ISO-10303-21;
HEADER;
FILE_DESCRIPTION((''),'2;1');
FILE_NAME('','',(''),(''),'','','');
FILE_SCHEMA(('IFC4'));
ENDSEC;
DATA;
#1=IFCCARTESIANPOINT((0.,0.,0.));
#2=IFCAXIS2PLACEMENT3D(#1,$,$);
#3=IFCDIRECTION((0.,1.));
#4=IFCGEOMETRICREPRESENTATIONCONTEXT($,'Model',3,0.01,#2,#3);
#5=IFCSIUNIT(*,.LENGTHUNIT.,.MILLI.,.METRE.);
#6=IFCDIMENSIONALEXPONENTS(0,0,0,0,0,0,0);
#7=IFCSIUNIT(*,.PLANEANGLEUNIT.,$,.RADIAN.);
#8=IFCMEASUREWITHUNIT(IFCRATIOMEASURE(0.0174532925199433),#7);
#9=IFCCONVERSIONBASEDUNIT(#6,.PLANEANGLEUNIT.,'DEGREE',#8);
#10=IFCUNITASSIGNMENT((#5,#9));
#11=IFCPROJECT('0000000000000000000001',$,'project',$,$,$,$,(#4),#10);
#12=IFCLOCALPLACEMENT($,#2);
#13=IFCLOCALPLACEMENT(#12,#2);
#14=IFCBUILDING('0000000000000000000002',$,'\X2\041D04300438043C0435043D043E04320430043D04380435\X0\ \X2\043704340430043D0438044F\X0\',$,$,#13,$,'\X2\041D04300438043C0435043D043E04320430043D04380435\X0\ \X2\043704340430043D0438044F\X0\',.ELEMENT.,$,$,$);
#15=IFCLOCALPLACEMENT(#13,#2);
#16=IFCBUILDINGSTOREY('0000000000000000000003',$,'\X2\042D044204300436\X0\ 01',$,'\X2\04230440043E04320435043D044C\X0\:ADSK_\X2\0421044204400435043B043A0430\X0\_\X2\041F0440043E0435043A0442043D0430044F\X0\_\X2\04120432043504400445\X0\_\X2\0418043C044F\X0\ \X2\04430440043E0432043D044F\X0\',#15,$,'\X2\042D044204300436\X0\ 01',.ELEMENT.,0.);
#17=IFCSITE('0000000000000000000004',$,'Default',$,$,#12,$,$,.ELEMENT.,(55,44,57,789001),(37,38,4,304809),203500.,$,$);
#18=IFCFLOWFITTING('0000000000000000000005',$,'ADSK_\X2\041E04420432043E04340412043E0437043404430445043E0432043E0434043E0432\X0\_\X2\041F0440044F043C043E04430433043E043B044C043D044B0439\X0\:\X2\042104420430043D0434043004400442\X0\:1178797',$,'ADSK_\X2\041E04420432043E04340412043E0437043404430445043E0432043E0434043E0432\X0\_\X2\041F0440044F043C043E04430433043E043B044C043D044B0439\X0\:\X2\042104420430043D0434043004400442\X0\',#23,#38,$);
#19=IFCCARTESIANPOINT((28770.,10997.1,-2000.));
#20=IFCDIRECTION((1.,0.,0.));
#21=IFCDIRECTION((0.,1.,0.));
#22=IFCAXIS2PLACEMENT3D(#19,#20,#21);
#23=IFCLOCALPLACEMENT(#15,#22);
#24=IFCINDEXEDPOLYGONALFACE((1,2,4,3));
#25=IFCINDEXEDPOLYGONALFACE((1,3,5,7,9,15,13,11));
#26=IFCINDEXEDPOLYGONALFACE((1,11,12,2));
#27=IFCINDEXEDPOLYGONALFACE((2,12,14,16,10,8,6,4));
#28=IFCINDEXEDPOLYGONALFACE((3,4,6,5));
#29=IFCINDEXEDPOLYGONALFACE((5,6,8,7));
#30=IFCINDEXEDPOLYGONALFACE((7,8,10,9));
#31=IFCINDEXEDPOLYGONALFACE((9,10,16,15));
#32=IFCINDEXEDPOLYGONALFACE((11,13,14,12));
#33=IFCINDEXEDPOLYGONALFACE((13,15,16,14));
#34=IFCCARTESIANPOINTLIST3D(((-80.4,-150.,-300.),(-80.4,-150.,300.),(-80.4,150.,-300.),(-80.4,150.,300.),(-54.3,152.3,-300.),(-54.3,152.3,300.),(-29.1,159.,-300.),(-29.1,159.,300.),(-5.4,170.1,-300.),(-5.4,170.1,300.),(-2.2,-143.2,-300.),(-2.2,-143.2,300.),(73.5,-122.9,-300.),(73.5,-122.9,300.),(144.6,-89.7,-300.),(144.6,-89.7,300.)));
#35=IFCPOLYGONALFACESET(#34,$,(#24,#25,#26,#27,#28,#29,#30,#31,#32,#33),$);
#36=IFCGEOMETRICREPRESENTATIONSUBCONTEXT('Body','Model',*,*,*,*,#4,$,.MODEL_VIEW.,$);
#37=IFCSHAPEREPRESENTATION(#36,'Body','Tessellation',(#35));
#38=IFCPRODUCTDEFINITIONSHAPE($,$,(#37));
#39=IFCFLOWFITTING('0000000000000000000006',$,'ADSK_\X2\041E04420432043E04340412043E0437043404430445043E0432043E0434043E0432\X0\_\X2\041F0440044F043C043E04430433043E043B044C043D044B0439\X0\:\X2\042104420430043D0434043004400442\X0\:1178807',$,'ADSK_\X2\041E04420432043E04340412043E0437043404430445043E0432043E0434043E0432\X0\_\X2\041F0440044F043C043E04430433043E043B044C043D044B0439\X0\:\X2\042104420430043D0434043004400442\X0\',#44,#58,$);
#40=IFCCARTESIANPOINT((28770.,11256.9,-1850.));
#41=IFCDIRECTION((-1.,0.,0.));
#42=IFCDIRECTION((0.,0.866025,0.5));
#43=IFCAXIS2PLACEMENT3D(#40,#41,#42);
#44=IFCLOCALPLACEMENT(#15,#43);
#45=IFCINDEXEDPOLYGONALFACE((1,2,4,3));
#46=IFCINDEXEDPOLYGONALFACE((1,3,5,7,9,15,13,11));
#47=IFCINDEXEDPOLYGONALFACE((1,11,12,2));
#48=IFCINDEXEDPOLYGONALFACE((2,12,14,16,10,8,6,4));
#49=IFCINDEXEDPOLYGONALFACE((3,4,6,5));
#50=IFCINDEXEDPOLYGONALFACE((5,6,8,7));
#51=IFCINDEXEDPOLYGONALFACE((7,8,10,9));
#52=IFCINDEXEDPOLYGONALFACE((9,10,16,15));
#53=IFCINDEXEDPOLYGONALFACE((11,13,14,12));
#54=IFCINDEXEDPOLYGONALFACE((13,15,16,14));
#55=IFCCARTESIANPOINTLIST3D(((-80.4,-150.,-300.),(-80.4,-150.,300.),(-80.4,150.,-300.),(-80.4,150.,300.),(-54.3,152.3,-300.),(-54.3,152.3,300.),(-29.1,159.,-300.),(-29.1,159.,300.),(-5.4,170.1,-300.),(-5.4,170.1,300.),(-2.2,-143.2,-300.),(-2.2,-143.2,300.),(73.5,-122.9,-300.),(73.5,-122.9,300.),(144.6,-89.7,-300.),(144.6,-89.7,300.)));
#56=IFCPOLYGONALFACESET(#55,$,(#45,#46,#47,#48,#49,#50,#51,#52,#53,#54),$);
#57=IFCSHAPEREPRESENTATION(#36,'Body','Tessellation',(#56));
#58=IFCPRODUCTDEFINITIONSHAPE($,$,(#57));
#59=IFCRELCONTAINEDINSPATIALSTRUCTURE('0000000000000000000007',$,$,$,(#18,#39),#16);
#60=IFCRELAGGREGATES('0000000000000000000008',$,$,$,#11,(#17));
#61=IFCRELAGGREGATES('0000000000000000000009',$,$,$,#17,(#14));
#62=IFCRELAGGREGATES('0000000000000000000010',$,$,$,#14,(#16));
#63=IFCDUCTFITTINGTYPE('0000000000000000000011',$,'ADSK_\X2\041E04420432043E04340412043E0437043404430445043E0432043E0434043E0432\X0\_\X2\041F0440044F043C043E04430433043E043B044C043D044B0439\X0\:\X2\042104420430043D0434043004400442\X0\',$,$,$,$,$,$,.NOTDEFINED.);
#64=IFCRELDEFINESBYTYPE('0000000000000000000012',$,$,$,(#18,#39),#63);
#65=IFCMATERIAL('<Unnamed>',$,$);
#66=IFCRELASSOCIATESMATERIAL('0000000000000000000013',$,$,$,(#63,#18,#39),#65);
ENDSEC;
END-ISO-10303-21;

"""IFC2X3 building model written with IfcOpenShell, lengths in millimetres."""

from ifc_helpers import new_model, entity, si_unit, converted_unit, direction, frame, frame_2d, origin, place, context, subcontext, project, spatial, polyline, circle_curve, parameter, trimmed, segment, composite_curve, outline, extrude, source, transform, mapped, material, type_object, type_shapes, element, save


model = new_model("IFC2X3")

# Units and contexts
model_context = context("Model", 3, precision=0.01, world=origin(), true_north=direction((0.0, 1.0)))
body_context = subcontext(model_context, "Body", "Model", "MODEL_VIEW")
ifc_project = project(units=[si_unit("LENGTHUNIT", "METRE", prefix="MILLI"), converted_unit("PLANEANGLEUNIT", "DEGREE", entity("IfcRatioMeasure", 0.0174532925199433), si_unit("PLANEANGLEUNIT", "RADIAN"), dimensions=[0, 0, 0, 0, 0, 0, 0])], contexts=[model_context])

# Site, building, storey
site_placement = place(None, origin())
site = spatial("IfcSite", under=ifc_project, at=site_placement, Name="Default", CompositionType="ELEMENT", RefLatitude=(55, 44, 57, 789001), RefLongitude=(37, 38, 4, 304809), RefElevation=203500.0)
building_placement = place(site_placement, origin())
building = spatial("IfcBuilding", under=site, at=building_placement, Name="Наименование здания", LongName="Наименование здания", CompositionType="ELEMENT")
storey_placement = place(building_placement, origin())
storey = spatial("IfcBuildingStorey", under=building, at=storey_placement, Name="Этаж 01", ObjectType="Уровень:ADSK_Стрелка_Проектная_Вверх_Имя уровня", LongName="Этаж 01", CompositionType="ELEMENT", Elevation=0.0)

# Shared definitions
ifc_material_1 = material(Name="<Unnamed>")

# Flow fittings
duct_fitting_type_1 = type_object("IfcDuctFittingType", Name="ADSK_ОтводВоздуховодов_Прямоугольный:Стандарт", PredefinedType="NOTDEFINED", material=ifc_material_1)
shared_shape_1 = source(origin(), body_context, "Body", "SweptSolid", [
    extrude(outline(composite_curve([segment(polyline([(-170.1, -75.0), (129.9, -75.0)]), True, "CONTINUOUS"), segment(trimmed(circle_curve(frame_2d((279.9, -75.0), x_axis=(-0.866025, 0.5)), 150.0), [parameter(0.0)], [parameter(29.999999)], True, "PARAMETER"), False, "CONTINUOUS"), segment(polyline([(150.0, 0.0), (-109.8, 150.0)]), True, "CONTINUOUS"), segment(trimmed(circle_curve(frame_2d((279.9, -75.0), x_axis=(-0.866025, 0.5)), 450.0), [parameter(0.0)], [parameter(29.999999)], True, "PARAMETER"), True, "CONTINUOUS")], self_intersect=False)), frame((-5.4, 20.1, -300.0), z_axis=(0.0, 0.0, 1.0), x_axis=(-0.5, 0.866025, 0.0)), (0.0, 0.0, 1.0), 600.0),
])
type_shapes(duct_fitting_type_1, [shared_shape_1])
for number, where, z_axis, x_axis, name in (
    (1, (28770.0, 10997.1, -2000.0), (1.0, 0.0, 0.0), (0.0, 1.0, 0.0), "ADSK_ОтводВоздуховодов_Прямоугольный:Стандарт:1178797"),
    (2, (28770.0, 11256.9, -1850.0), (-1.0, 0.0, 0.0), (0.0, 0.866025, 0.5), "ADSK_ОтводВоздуховодов_Прямоугольный:Стандарт:1178807"),
):
    element("IfcFlowFitting", number, at=place(storey_placement, frame(where, z_axis=z_axis, x_axis=x_axis)), inside=storey, type_object=duct_fitting_type_1, material=ifc_material_1, Name=name, ObjectType="ADSK_ОтводВоздуховодов_Прямоугольный:Стандарт", context=body_context, shape_type="MappedRepresentation", body=[
        mapped(shared_shape_1, transform((0.0, 0.0, 0.0), scale=1.0)),
    ])

save(model, "model.ifc")
